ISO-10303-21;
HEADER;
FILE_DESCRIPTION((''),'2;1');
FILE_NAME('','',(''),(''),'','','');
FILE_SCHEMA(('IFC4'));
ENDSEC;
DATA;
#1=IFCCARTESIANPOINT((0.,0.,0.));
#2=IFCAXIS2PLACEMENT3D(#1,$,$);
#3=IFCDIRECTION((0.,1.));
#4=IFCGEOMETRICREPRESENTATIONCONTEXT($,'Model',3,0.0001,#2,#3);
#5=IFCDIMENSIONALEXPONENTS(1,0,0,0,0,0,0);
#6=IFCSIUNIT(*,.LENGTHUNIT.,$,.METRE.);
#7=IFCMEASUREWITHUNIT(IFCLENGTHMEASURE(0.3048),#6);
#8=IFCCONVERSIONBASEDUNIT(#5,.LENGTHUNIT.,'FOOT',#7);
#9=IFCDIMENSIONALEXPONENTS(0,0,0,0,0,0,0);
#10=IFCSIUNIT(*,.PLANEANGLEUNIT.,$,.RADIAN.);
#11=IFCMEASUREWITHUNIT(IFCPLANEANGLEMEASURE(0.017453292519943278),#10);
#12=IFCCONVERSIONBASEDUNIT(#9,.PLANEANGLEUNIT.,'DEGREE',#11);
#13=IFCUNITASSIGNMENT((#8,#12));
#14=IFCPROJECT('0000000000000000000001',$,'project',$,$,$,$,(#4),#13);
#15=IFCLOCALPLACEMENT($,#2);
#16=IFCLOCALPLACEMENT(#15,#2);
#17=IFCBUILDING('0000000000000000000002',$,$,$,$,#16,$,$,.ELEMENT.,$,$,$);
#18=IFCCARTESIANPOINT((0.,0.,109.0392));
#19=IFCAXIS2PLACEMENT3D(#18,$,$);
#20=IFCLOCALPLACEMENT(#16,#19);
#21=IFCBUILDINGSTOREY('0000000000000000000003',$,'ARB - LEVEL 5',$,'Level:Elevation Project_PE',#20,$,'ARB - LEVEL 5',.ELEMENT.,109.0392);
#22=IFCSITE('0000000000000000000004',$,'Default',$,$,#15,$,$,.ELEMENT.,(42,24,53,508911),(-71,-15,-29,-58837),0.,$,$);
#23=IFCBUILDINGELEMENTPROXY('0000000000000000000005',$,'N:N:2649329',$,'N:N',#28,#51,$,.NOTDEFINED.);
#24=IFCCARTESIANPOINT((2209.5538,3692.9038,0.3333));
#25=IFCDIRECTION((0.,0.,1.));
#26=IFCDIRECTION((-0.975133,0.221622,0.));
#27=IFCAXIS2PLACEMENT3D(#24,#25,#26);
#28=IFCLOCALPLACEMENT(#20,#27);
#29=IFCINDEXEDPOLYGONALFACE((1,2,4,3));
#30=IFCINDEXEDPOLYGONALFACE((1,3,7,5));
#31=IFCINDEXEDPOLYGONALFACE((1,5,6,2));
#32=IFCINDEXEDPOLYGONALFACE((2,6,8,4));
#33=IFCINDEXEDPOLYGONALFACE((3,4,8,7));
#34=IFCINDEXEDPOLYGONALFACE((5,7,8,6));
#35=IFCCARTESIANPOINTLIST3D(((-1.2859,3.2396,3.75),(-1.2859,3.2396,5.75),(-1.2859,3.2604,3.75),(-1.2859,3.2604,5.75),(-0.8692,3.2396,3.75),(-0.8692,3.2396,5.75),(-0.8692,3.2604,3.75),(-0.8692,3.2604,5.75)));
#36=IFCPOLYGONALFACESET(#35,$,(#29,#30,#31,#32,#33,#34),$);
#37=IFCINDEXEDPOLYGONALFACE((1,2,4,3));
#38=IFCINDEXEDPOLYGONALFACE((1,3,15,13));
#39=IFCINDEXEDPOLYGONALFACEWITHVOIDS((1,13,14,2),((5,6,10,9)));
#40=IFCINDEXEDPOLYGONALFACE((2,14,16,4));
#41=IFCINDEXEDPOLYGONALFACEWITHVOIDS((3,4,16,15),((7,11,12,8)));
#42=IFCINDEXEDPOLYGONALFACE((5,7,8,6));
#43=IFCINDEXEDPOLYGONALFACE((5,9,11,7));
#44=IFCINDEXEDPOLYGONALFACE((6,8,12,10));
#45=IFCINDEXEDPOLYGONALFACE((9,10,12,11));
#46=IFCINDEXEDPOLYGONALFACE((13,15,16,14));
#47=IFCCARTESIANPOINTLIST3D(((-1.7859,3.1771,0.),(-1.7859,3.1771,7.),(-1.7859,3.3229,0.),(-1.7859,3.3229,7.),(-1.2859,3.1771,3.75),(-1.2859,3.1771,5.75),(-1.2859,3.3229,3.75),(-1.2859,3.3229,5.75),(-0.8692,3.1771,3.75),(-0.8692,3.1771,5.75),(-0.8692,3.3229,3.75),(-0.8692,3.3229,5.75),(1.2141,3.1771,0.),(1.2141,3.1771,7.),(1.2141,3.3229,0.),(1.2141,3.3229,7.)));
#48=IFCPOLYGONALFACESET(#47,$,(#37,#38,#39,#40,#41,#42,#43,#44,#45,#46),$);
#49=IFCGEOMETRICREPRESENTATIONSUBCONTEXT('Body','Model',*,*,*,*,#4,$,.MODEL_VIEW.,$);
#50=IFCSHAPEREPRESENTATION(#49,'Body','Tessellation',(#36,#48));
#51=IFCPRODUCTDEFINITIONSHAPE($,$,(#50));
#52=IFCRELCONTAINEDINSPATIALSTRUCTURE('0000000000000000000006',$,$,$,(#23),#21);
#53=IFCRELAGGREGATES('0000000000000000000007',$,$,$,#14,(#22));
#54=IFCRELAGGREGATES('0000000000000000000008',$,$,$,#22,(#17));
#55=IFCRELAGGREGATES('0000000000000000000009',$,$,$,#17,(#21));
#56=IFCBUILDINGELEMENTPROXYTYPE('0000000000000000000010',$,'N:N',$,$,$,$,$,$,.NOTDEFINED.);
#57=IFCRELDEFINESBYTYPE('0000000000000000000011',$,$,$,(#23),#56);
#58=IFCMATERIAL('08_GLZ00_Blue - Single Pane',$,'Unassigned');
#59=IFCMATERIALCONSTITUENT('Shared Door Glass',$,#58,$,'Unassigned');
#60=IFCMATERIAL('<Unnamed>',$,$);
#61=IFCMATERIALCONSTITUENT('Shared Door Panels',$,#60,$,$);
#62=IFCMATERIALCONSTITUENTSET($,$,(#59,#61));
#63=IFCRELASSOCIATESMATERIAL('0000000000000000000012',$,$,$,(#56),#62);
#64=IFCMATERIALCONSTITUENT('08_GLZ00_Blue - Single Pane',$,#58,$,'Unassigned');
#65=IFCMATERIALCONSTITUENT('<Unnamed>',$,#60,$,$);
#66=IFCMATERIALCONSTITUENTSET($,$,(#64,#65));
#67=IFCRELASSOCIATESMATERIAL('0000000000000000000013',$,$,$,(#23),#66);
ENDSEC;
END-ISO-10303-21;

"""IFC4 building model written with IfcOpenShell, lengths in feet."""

from ifc_helpers import new_model, entity, si_unit, converted_unit, direction, frame, origin, place, context, subcontext, project, spatial, indexed_curve, outline, extrude, source, transform, mapped, material, constituent, constituent_set, type_object, type_shapes, element, save


model = new_model("IFC4")

# Units and contexts
model_context = context("Model", 3, precision=0.0001, world=origin(), true_north=direction((0.0, 1.0)))
body_context = subcontext(model_context, "Body", "Model", "MODEL_VIEW")
ifc_project = project(units=[converted_unit("LENGTHUNIT", "FOOT", entity("IfcLengthMeasure", 0.3048), si_unit("LENGTHUNIT", "METRE"), dimensions=[1, 0, 0, 0, 0, 0, 0]), converted_unit("PLANEANGLEUNIT", "DEGREE", entity("IfcPlaneAngleMeasure", 0.017453292519943278), si_unit("PLANEANGLEUNIT", "RADIAN"), dimensions=[0, 0, 0, 0, 0, 0, 0])], contexts=[model_context])

# Site, building, storey
site_placement = place(None, origin())
site = spatial("IfcSite", under=ifc_project, at=site_placement, Name="Default", CompositionType="ELEMENT", RefLatitude=(42, 24, 53, 508911), RefLongitude=(-71, -15, -29, -58837), RefElevation=0.0)
building_placement = place(site_placement, origin())
building = spatial("IfcBuilding", under=site, at=building_placement, CompositionType="ELEMENT")
storey_placement = place(building_placement, frame((0.0, 0.0, 109.0392)))
storey = spatial("IfcBuildingStorey", under=building, at=storey_placement, Name="ARB - LEVEL 5", ObjectType="Level:Elevation Project_PE", LongName="ARB - LEVEL 5", CompositionType="ELEMENT", Elevation=109.0392)

# Shared definitions
ifc_material_1 = material(Name="<Unnamed>")

# Building element proxy
ifc_material_2 = material(Name="08_GLZ00_Blue - Single Pane", Category="Unassigned")
ifc_constituent_1 = constituent(ifc_material_2, Name="08_GLZ00_Blue - Single Pane", Category="Unassigned")
ifc_constituent_2 = constituent(ifc_material_1, Name="<Unnamed>")
ifc_constituent_set_1 = constituent_set(constituents=[ifc_constituent_1, ifc_constituent_2])
ifc_constituent_3 = constituent(ifc_material_2, Name="Shared Door Glass", Category="Unassigned")
ifc_constituent_4 = constituent(ifc_material_1, Name="Shared Door Panels")
ifc_constituent_set_2 = constituent_set(constituents=[ifc_constituent_3, ifc_constituent_4])
building_element_proxy_type_1 = type_object("IfcBuildingElementProxyType", Name="N:N", PredefinedType="NOTDEFINED", material=ifc_constituent_set_2)
shared_shape_1 = source(origin(), body_context, "Body", "SweptSolid", [
    extrude(outline(indexed_curve([(-0.0104, -0.2083), (0.0104, -0.2083), (0.0104, 0.2083), (-0.0104, 0.2083), (-0.0104, -0.2083)], self_intersect=False)), frame((-1.0775, 3.25, 3.75), z_axis=(0.0, 0.0, 1.0), x_axis=(0.0, 1.0, 0.0)), (0.0, 0.0, 1.0), 2.0),
    extrude(outline(indexed_curve([(-3.5, -1.5), (3.5, -1.5), (3.5, 1.5), (-3.5, 1.5), (-3.5, -1.5)], self_intersect=False), holes=[indexed_curve([(-2.25, 0.5833), (-2.25, 1.0), (-0.25, 1.0), (-0.25, 0.5833), (-2.25, 0.5833)], self_intersect=False)]), frame((-0.2859, 3.1771, 3.5), z_axis=(0.0, 1.0, 0.0), x_axis=(0.0, 0.0, -1.0)), (0.0, 0.0, 1.0), 0.1458),
])
type_shapes(building_element_proxy_type_1, [shared_shape_1])
proxy_1_placement = place(storey_placement, frame((2209.5538, 3692.9038, 0.3333), z_axis=(0.0, 0.0, 1.0), x_axis=(-0.975133, 0.221622, 0.0)))
element("IfcBuildingElementProxy", 1, at=proxy_1_placement, inside=storey, type_object=building_element_proxy_type_1, material=ifc_constituent_set_1, Name="N:N:2649329", ObjectType="N:N", PredefinedType="NOTDEFINED", context=body_context, shape_type="MappedRepresentation", body=[
    mapped(shared_shape_1, transform((0.0, 0.0, 0.0), scale=1.0)),
])

save(model, "model.ifc")
